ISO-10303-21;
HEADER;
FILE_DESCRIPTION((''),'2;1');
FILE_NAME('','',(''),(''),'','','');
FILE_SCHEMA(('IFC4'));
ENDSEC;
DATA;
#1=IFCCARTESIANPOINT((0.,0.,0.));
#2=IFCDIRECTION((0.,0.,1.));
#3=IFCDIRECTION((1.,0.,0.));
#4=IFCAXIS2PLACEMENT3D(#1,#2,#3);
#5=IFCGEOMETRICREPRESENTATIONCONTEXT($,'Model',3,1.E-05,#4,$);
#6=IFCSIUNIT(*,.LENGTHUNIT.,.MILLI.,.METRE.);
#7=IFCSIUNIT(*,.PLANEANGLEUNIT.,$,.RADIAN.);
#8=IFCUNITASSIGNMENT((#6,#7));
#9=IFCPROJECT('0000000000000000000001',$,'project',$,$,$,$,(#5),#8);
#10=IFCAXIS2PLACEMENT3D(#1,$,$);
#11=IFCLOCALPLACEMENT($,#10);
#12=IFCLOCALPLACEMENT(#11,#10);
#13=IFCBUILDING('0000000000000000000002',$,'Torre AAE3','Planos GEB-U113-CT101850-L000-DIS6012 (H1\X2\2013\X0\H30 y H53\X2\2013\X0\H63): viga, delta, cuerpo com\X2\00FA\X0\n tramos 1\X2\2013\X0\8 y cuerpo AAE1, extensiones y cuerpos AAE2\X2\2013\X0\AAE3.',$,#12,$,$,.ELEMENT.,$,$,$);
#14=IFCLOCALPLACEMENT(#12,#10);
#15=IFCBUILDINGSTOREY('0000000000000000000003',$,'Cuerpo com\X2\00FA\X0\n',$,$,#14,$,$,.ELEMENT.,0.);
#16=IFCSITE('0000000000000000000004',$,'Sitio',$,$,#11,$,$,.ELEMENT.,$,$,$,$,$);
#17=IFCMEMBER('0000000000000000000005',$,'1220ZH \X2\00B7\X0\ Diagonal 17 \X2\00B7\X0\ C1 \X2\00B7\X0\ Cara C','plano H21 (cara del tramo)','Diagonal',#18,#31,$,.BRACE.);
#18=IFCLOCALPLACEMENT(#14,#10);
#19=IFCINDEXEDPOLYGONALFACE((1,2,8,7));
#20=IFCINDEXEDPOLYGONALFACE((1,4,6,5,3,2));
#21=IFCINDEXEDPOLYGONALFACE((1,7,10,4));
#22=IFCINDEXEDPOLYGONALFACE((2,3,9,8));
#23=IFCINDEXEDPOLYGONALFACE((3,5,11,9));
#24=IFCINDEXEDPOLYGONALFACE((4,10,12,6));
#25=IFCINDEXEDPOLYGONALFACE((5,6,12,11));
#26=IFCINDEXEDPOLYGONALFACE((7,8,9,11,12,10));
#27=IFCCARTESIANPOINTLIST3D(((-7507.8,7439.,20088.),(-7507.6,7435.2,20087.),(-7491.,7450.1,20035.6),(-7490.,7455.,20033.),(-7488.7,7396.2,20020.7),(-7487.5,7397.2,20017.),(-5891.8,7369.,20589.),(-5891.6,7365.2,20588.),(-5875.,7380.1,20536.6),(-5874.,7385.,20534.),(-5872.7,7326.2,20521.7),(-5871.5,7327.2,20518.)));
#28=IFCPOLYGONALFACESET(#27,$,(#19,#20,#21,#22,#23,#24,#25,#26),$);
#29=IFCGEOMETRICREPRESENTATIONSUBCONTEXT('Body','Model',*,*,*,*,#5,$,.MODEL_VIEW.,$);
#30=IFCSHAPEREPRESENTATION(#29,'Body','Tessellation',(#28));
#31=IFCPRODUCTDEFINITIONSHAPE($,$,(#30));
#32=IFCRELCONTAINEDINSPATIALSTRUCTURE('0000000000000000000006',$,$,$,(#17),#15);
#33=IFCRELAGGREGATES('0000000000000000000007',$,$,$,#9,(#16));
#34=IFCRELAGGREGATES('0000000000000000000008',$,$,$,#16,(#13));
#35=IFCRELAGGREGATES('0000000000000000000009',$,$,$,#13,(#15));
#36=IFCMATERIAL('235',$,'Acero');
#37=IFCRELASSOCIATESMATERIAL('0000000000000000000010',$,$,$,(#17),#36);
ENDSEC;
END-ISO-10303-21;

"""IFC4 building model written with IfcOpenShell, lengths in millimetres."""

from ifc_helpers import new_model, si_unit, frame, frame_2d, origin, origin_with_axes, place, context, subcontext, project, spatial, l_section, extrude, material, element, save


model = new_model("IFC4")

# Units and contexts
model_context = context("Model", 3, precision=1e-05, world=origin_with_axes())
body_context = subcontext(model_context, "Body", "Model", "MODEL_VIEW")
ifc_project = project(units=[si_unit("LENGTHUNIT", "METRE", prefix="MILLI"), si_unit("PLANEANGLEUNIT", "RADIAN")], contexts=[model_context])

# Site, building, storey
site_placement = place(None, origin())
site = spatial("IfcSite", under=ifc_project, at=site_placement, Name="Sitio", CompositionType="ELEMENT")
building_placement = place(site_placement, origin())
building = spatial("IfcBuilding", under=site, at=building_placement, Name="Torre AAE3", Description="Planos GEB-U113-CT101850-L000-DIS6012 (H1–H30 y H53–H63): viga, delta, cuerpo común tramos 1–8 y cuerpo AAE1, extensiones y cuerpos AAE2–AAE3.", CompositionType="ELEMENT")
storey_placement = place(building_placement, origin())
storey = spatial("IfcBuildingStorey", under=building, at=storey_placement, Name="Cuerpo común", CompositionType="ELEMENT", Elevation=0.0)

# Member
ifc_material_1 = material(Name="235", Category="Acero")
member_1_placement = place(storey_placement, frame((-5874.0, 7385.0, 20534.0), z_axis=(-0.954334, 0.041339, -0.295867), x_axis=(0.040927, -0.96295, -0.266555)))
element("IfcMember", 1, at=member_1_placement, inside=storey, material=ifc_material_1, Name="1220ZH · Diagonal 17 · C1 · Cara C", Description="plano H21 (cara del tramo)", ObjectType="Diagonal", PredefinedType="BRACE", context=body_context, shape_type="SweptSolid", body=[
    extrude(l_section(Depth=60.0, Width=60.0, Thickness=4.0, at=frame_2d((30.0, 30.0))), None, (0.0, 0.0, 1.0), 1693.3),
])

save(model, "model.ifc")
